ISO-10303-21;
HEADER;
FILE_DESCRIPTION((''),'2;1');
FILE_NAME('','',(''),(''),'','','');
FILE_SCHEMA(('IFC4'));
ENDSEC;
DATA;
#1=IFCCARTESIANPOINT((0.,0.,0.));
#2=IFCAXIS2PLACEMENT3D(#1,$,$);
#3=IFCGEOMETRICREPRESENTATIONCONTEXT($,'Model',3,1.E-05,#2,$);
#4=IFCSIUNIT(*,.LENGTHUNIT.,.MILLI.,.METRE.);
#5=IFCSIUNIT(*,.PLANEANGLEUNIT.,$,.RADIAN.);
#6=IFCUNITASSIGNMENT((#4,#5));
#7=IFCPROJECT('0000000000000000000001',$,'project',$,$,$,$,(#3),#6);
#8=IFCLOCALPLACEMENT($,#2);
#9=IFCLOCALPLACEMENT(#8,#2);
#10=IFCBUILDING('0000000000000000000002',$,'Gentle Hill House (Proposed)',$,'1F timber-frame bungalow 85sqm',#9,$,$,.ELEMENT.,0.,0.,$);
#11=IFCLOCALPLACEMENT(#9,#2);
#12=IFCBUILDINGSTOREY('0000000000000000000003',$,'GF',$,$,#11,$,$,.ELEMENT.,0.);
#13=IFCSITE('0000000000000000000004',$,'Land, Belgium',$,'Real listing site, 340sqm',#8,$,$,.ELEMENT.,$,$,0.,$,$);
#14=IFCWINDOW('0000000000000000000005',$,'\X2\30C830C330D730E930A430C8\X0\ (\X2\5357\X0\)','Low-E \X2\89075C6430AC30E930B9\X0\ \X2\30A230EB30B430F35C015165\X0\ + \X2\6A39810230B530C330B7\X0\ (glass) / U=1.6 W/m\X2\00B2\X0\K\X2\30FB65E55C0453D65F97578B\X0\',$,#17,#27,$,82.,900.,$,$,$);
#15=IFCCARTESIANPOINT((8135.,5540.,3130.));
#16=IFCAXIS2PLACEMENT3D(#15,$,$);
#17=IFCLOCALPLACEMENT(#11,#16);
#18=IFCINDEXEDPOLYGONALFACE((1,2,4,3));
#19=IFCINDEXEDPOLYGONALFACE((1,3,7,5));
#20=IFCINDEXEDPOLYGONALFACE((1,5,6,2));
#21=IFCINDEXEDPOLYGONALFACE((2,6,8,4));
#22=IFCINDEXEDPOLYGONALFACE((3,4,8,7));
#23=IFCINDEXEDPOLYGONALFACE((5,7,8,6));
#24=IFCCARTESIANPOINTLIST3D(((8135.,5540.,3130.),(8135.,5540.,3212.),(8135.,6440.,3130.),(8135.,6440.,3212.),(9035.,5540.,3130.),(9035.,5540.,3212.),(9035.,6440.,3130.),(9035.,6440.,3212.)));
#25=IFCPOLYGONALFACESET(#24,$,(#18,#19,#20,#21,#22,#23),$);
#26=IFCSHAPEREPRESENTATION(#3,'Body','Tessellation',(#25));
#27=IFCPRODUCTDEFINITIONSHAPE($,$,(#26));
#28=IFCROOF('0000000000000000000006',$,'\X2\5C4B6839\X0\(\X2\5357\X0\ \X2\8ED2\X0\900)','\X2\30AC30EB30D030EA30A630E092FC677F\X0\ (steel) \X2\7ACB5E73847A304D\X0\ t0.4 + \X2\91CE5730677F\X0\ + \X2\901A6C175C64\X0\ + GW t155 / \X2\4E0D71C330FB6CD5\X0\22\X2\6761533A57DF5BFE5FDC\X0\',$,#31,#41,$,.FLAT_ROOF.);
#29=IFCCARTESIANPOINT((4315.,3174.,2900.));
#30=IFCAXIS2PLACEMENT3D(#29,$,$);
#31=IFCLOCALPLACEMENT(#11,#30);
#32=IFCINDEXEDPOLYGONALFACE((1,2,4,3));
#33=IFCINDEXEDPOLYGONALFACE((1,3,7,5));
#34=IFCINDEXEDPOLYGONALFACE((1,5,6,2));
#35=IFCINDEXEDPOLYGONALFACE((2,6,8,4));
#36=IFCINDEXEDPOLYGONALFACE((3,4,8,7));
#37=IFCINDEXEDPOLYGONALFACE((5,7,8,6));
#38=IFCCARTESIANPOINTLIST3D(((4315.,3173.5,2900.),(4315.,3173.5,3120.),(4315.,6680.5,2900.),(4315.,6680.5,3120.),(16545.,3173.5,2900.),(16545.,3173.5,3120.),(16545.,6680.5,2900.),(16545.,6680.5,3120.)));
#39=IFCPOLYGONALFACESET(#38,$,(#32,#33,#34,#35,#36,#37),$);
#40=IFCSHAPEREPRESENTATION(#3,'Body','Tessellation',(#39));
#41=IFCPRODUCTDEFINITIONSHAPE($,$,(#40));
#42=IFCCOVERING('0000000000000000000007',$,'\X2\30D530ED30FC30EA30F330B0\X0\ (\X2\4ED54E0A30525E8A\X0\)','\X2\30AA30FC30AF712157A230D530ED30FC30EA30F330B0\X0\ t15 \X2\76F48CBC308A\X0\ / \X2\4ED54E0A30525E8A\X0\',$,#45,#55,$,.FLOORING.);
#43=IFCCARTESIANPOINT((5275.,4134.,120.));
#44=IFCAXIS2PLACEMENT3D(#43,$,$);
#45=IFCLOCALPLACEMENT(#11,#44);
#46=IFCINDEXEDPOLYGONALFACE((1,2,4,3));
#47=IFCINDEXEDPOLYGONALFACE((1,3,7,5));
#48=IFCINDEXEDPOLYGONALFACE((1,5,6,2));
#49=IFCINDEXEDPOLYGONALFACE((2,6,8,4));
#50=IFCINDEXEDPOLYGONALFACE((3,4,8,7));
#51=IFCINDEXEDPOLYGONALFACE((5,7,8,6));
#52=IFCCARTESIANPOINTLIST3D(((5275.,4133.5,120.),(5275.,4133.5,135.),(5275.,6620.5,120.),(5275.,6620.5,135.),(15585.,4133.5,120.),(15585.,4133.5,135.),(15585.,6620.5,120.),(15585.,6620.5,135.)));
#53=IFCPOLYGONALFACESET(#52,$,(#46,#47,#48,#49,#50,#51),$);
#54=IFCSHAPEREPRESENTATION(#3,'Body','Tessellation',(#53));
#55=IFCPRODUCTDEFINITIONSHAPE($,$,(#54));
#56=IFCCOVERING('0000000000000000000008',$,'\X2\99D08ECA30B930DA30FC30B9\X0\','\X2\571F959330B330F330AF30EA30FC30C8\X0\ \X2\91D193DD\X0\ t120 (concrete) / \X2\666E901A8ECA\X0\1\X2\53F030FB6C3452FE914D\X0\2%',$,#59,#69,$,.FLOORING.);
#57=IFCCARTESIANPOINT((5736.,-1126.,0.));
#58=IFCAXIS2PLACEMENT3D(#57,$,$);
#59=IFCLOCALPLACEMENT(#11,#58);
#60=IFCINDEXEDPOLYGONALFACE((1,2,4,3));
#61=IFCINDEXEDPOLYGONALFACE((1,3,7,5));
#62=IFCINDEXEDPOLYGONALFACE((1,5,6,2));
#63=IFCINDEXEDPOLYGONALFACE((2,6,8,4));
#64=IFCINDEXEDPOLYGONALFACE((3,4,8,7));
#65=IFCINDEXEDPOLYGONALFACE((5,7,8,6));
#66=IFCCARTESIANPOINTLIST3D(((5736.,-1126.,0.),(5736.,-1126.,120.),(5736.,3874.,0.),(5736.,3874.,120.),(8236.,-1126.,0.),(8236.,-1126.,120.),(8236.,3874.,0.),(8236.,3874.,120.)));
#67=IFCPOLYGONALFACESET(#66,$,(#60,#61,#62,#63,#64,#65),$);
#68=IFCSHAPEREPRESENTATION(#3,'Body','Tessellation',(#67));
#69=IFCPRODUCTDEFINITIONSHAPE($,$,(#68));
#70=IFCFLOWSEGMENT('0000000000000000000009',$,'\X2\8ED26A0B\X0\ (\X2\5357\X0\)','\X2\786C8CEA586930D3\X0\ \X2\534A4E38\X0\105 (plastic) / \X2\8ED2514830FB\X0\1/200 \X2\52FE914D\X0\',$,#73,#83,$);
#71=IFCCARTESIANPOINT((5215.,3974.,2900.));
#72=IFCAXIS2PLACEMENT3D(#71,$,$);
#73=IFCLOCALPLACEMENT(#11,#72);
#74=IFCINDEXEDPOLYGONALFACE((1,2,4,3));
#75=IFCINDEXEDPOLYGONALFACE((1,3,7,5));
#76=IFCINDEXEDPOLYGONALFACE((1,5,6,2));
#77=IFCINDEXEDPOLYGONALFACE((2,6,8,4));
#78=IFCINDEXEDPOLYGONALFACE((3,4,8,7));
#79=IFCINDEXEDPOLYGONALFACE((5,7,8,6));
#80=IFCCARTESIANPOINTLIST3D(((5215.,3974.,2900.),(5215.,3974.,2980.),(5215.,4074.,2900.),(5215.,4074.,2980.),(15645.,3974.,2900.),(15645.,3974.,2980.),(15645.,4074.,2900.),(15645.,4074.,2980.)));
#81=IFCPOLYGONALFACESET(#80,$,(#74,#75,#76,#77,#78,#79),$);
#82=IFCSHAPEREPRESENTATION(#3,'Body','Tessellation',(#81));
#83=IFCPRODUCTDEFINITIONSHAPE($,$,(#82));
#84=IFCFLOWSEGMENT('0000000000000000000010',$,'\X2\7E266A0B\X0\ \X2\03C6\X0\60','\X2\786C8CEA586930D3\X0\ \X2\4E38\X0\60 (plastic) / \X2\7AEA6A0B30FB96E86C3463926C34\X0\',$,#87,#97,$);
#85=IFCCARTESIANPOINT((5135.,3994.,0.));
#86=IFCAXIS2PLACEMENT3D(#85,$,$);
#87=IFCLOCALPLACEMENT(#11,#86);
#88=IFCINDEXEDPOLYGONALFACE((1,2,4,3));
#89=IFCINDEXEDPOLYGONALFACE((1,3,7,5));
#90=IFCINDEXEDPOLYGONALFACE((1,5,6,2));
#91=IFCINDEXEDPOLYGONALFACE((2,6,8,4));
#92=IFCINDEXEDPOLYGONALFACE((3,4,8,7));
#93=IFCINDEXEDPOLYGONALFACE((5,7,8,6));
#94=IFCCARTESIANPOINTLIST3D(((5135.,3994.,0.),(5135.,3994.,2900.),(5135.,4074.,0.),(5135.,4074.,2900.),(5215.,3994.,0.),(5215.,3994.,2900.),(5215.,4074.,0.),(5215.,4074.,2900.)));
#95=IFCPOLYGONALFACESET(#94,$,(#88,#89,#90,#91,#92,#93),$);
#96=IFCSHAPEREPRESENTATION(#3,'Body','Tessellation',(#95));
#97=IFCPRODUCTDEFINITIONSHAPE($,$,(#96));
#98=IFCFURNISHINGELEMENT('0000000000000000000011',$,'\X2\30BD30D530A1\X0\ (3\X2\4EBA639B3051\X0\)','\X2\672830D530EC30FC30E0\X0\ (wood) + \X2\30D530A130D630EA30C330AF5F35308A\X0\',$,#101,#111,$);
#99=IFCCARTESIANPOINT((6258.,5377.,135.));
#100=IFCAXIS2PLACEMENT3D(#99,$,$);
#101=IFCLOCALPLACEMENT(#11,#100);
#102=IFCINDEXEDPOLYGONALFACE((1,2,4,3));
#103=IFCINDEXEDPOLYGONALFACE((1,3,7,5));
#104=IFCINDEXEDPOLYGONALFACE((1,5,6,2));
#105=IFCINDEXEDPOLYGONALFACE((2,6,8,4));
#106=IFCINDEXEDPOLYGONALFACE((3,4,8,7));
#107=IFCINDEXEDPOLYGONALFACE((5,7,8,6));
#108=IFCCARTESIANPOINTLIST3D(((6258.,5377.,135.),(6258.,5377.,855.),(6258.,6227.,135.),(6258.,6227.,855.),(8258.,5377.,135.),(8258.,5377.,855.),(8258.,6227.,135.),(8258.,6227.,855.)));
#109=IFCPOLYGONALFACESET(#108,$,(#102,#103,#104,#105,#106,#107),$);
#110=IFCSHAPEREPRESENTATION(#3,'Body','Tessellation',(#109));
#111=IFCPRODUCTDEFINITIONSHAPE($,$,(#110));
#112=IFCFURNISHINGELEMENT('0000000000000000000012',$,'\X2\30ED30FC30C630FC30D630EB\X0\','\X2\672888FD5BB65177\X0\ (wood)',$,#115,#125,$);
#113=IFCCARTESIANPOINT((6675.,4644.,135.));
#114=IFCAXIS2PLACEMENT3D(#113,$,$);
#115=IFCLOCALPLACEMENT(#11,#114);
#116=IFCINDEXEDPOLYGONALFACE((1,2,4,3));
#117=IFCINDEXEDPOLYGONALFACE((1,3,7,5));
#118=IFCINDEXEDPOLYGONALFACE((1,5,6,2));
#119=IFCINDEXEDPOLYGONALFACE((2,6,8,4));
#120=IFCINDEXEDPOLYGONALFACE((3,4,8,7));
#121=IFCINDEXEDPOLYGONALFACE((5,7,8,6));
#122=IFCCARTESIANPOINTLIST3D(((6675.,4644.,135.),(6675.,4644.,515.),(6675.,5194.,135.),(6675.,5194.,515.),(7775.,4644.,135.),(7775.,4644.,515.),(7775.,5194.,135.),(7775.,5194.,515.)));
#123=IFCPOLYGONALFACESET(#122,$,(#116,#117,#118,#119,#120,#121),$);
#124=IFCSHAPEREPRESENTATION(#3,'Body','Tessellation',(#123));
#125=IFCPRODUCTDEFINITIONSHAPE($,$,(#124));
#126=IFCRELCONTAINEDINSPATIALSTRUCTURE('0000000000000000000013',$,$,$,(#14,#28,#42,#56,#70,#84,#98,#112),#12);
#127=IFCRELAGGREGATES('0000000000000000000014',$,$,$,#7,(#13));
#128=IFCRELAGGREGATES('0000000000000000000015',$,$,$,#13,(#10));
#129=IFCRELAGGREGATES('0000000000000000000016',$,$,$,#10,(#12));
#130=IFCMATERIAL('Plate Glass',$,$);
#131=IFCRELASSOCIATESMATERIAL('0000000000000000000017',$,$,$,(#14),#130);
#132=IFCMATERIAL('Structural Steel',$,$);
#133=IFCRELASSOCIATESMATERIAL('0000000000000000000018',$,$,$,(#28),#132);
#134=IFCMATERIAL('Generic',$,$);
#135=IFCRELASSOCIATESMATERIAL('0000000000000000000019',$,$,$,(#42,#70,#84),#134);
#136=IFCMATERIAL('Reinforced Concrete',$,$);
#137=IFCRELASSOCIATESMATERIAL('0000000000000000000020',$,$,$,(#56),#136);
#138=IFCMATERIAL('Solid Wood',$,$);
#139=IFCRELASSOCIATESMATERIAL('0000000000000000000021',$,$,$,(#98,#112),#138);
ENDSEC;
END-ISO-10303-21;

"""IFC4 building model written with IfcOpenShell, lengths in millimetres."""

from ifc_helpers import new_model, si_unit, frame, frame_2d, origin, place, context, project, spatial, rectangle, extrude, material, element, save


model = new_model("IFC4")

# Units and contexts
model_context = context("Model", 3, precision=1e-05, world=origin())
ifc_project = project(units=[si_unit("LENGTHUNIT", "METRE", prefix="MILLI"), si_unit("PLANEANGLEUNIT", "RADIAN")], contexts=[model_context])

# Site, building, storey
site_placement = place(None, origin())
site = spatial("IfcSite", under=ifc_project, at=site_placement, Name="Land, Belgium", ObjectType="Real listing site, 340sqm", CompositionType="ELEMENT", RefElevation=0.0)
building_placement = place(site_placement, origin())
building = spatial("IfcBuilding", under=site, at=building_placement, Name="Gentle Hill House (Proposed)", ObjectType="1F timber-frame bungalow 85sqm", CompositionType="ELEMENT", ElevationOfRefHeight=0.0, ElevationOfTerrain=0.0)
storey_placement = place(building_placement, origin())
storey = spatial("IfcBuildingStorey", under=building, at=storey_placement, Name="GF", CompositionType="ELEMENT", Elevation=0.0)

# Shared definitions
ifc_material_1 = material(Name="Solid Wood")

# Shared definitions
ifc_material_2 = material(Name="Reinforced Concrete")

# Shared definitions
ifc_material_3 = material(Name="Plate Glass")

# Window
window_1_placement = place(storey_placement, frame((8135.0, 5540.0, 3130.0)))
element("IfcWindow", 1, at=window_1_placement, inside=storey, material=ifc_material_3, Name="トップライト (南)", Description="Low-E 複層ガラス アルゴン封入 + 樹脂サッシ (glass) / U=1.6 W/m²K・日射取得型", OverallHeight=82.0, OverallWidth=900.0, context=model_context, shape_type="SweptSolid", body=[
    extrude(rectangle(XDim=900.0, YDim=900.0, at=frame_2d((450.0, 450.0))), frame((8135.0, 5540.0, 3130.0)), (0.0, 0.0, 1.0), 82.0),
])

# Roof
ifc_material_4 = material(Name="Structural Steel")
roof_1_placement = place(storey_placement, frame((4315.0, 3174.0, 2900.0)))
element("IfcRoof", 2, at=roof_1_placement, inside=storey, material=ifc_material_4, Name="屋根(南 軒900)", Description="ガルバリウム鋼板 (steel) 立平葺き t0.4 + 野地板 + 通気層 + GW t155 / 不燃・法22条区域対応", PredefinedType="FLAT_ROOF", context=model_context, shape_type="SweptSolid", body=[
    extrude(rectangle(XDim=12230.0, YDim=3507.0, at=frame_2d((6115.0, 1753.0))), frame((4315.0, 3174.0, 2900.0)), (0.0, 0.0, 1.0), 220.0),
])

# Coverings
ifc_material_5 = material(Name="Generic")
covering_1_placement = place(storey_placement, frame((5275.0, 4134.0, 120.0)))
element("IfcCovering", 3, at=covering_1_placement, inside=storey, material=ifc_material_5, Name="フローリング (仕上げ床)", Description="オーク無垢フローリング t15 直貼り / 仕上げ床", PredefinedType="FLOORING", context=model_context, shape_type="SweptSolid", body=[
    extrude(rectangle(XDim=10310.0, YDim=2487.0, at=frame_2d((5155.0, 1243.0))), frame((5275.0, 4134.0, 120.0)), (0.0, 0.0, 1.0), 15.0),
])
covering_2_placement = place(storey_placement, frame((5736.0, -1126.0, 0.0)))
element("IfcCovering", 4, at=covering_2_placement, inside=storey, material=ifc_material_2, Name="駐車スペース", Description="土間コンクリート 金鏝 t120 (concrete) / 普通車1台・水勾配2%", PredefinedType="FLOORING", context=model_context, shape_type="SweptSolid", body=[
    extrude(rectangle(XDim=2500.0, YDim=5000.0, at=frame_2d((1250.0, 2500.0))), frame((5736.0, -1126.0, 0.0)), (0.0, 0.0, 1.0), 120.0),
])

# Flow segments
flow_segment_1_placement = place(storey_placement, frame((5215.0, 3974.0, 2900.0)))
element("IfcFlowSegment", 5, at=flow_segment_1_placement, inside=storey, material=ifc_material_5, Name="軒樋 (南)", Description="硬質塩ビ 半丸105 (plastic) / 軒先・1/200 勾配", context=model_context, shape_type="SweptSolid", body=[
    extrude(rectangle(XDim=10430.0, YDim=100.0, at=frame_2d((5215.0, 50.0))), frame((5215.0, 3974.0, 2900.0)), (0.0, 0.0, 1.0), 80.0),
])
flow_segment_2_placement = place(storey_placement, frame((5135.0, 3994.0, 0.0)))
element("IfcFlowSegment", 6, at=flow_segment_2_placement, inside=storey, material=ifc_material_5, Name="縦樋 φ60", Description="硬質塩ビ 丸60 (plastic) / 竪樋・雨水排水", context=model_context, shape_type="SweptSolid", body=[
    extrude(rectangle(XDim=80.0, YDim=80.0, at=frame_2d((40.0, 40.0))), frame((5135.0, 3994.0, 0.0)), (0.0, 0.0, 1.0), 2900.0),
])

# Furnishing elements
furnishing_1_placement = place(storey_placement, frame((6258.0, 5377.0, 135.0)))
element("IfcFurnishingElement", 7, at=furnishing_1_placement, inside=storey, material=ifc_material_1, Name="ソファ (3人掛け)", Description="木フレーム (wood) + ファブリック張り", context=model_context, shape_type="SweptSolid", body=[
    extrude(rectangle(XDim=2000.0, YDim=850.0, at=frame_2d((1000.0, 425.0))), frame((6258.0, 5377.0, 135.0)), (0.0, 0.0, 1.0), 720.0),
])
furnishing_2_placement = place(storey_placement, frame((6675.0, 4644.0, 135.0)))
element("IfcFurnishingElement", 8, at=furnishing_2_placement, inside=storey, material=ifc_material_1, Name="ローテーブル", Description="木製家具 (wood)", context=model_context, shape_type="SweptSolid", body=[
    extrude(rectangle(XDim=1100.0, YDim=550.0, at=frame_2d((550.0, 275.0))), frame((6675.0, 4644.0, 135.0)), (0.0, 0.0, 1.0), 380.0),
])

save(model, "model.ifc")
